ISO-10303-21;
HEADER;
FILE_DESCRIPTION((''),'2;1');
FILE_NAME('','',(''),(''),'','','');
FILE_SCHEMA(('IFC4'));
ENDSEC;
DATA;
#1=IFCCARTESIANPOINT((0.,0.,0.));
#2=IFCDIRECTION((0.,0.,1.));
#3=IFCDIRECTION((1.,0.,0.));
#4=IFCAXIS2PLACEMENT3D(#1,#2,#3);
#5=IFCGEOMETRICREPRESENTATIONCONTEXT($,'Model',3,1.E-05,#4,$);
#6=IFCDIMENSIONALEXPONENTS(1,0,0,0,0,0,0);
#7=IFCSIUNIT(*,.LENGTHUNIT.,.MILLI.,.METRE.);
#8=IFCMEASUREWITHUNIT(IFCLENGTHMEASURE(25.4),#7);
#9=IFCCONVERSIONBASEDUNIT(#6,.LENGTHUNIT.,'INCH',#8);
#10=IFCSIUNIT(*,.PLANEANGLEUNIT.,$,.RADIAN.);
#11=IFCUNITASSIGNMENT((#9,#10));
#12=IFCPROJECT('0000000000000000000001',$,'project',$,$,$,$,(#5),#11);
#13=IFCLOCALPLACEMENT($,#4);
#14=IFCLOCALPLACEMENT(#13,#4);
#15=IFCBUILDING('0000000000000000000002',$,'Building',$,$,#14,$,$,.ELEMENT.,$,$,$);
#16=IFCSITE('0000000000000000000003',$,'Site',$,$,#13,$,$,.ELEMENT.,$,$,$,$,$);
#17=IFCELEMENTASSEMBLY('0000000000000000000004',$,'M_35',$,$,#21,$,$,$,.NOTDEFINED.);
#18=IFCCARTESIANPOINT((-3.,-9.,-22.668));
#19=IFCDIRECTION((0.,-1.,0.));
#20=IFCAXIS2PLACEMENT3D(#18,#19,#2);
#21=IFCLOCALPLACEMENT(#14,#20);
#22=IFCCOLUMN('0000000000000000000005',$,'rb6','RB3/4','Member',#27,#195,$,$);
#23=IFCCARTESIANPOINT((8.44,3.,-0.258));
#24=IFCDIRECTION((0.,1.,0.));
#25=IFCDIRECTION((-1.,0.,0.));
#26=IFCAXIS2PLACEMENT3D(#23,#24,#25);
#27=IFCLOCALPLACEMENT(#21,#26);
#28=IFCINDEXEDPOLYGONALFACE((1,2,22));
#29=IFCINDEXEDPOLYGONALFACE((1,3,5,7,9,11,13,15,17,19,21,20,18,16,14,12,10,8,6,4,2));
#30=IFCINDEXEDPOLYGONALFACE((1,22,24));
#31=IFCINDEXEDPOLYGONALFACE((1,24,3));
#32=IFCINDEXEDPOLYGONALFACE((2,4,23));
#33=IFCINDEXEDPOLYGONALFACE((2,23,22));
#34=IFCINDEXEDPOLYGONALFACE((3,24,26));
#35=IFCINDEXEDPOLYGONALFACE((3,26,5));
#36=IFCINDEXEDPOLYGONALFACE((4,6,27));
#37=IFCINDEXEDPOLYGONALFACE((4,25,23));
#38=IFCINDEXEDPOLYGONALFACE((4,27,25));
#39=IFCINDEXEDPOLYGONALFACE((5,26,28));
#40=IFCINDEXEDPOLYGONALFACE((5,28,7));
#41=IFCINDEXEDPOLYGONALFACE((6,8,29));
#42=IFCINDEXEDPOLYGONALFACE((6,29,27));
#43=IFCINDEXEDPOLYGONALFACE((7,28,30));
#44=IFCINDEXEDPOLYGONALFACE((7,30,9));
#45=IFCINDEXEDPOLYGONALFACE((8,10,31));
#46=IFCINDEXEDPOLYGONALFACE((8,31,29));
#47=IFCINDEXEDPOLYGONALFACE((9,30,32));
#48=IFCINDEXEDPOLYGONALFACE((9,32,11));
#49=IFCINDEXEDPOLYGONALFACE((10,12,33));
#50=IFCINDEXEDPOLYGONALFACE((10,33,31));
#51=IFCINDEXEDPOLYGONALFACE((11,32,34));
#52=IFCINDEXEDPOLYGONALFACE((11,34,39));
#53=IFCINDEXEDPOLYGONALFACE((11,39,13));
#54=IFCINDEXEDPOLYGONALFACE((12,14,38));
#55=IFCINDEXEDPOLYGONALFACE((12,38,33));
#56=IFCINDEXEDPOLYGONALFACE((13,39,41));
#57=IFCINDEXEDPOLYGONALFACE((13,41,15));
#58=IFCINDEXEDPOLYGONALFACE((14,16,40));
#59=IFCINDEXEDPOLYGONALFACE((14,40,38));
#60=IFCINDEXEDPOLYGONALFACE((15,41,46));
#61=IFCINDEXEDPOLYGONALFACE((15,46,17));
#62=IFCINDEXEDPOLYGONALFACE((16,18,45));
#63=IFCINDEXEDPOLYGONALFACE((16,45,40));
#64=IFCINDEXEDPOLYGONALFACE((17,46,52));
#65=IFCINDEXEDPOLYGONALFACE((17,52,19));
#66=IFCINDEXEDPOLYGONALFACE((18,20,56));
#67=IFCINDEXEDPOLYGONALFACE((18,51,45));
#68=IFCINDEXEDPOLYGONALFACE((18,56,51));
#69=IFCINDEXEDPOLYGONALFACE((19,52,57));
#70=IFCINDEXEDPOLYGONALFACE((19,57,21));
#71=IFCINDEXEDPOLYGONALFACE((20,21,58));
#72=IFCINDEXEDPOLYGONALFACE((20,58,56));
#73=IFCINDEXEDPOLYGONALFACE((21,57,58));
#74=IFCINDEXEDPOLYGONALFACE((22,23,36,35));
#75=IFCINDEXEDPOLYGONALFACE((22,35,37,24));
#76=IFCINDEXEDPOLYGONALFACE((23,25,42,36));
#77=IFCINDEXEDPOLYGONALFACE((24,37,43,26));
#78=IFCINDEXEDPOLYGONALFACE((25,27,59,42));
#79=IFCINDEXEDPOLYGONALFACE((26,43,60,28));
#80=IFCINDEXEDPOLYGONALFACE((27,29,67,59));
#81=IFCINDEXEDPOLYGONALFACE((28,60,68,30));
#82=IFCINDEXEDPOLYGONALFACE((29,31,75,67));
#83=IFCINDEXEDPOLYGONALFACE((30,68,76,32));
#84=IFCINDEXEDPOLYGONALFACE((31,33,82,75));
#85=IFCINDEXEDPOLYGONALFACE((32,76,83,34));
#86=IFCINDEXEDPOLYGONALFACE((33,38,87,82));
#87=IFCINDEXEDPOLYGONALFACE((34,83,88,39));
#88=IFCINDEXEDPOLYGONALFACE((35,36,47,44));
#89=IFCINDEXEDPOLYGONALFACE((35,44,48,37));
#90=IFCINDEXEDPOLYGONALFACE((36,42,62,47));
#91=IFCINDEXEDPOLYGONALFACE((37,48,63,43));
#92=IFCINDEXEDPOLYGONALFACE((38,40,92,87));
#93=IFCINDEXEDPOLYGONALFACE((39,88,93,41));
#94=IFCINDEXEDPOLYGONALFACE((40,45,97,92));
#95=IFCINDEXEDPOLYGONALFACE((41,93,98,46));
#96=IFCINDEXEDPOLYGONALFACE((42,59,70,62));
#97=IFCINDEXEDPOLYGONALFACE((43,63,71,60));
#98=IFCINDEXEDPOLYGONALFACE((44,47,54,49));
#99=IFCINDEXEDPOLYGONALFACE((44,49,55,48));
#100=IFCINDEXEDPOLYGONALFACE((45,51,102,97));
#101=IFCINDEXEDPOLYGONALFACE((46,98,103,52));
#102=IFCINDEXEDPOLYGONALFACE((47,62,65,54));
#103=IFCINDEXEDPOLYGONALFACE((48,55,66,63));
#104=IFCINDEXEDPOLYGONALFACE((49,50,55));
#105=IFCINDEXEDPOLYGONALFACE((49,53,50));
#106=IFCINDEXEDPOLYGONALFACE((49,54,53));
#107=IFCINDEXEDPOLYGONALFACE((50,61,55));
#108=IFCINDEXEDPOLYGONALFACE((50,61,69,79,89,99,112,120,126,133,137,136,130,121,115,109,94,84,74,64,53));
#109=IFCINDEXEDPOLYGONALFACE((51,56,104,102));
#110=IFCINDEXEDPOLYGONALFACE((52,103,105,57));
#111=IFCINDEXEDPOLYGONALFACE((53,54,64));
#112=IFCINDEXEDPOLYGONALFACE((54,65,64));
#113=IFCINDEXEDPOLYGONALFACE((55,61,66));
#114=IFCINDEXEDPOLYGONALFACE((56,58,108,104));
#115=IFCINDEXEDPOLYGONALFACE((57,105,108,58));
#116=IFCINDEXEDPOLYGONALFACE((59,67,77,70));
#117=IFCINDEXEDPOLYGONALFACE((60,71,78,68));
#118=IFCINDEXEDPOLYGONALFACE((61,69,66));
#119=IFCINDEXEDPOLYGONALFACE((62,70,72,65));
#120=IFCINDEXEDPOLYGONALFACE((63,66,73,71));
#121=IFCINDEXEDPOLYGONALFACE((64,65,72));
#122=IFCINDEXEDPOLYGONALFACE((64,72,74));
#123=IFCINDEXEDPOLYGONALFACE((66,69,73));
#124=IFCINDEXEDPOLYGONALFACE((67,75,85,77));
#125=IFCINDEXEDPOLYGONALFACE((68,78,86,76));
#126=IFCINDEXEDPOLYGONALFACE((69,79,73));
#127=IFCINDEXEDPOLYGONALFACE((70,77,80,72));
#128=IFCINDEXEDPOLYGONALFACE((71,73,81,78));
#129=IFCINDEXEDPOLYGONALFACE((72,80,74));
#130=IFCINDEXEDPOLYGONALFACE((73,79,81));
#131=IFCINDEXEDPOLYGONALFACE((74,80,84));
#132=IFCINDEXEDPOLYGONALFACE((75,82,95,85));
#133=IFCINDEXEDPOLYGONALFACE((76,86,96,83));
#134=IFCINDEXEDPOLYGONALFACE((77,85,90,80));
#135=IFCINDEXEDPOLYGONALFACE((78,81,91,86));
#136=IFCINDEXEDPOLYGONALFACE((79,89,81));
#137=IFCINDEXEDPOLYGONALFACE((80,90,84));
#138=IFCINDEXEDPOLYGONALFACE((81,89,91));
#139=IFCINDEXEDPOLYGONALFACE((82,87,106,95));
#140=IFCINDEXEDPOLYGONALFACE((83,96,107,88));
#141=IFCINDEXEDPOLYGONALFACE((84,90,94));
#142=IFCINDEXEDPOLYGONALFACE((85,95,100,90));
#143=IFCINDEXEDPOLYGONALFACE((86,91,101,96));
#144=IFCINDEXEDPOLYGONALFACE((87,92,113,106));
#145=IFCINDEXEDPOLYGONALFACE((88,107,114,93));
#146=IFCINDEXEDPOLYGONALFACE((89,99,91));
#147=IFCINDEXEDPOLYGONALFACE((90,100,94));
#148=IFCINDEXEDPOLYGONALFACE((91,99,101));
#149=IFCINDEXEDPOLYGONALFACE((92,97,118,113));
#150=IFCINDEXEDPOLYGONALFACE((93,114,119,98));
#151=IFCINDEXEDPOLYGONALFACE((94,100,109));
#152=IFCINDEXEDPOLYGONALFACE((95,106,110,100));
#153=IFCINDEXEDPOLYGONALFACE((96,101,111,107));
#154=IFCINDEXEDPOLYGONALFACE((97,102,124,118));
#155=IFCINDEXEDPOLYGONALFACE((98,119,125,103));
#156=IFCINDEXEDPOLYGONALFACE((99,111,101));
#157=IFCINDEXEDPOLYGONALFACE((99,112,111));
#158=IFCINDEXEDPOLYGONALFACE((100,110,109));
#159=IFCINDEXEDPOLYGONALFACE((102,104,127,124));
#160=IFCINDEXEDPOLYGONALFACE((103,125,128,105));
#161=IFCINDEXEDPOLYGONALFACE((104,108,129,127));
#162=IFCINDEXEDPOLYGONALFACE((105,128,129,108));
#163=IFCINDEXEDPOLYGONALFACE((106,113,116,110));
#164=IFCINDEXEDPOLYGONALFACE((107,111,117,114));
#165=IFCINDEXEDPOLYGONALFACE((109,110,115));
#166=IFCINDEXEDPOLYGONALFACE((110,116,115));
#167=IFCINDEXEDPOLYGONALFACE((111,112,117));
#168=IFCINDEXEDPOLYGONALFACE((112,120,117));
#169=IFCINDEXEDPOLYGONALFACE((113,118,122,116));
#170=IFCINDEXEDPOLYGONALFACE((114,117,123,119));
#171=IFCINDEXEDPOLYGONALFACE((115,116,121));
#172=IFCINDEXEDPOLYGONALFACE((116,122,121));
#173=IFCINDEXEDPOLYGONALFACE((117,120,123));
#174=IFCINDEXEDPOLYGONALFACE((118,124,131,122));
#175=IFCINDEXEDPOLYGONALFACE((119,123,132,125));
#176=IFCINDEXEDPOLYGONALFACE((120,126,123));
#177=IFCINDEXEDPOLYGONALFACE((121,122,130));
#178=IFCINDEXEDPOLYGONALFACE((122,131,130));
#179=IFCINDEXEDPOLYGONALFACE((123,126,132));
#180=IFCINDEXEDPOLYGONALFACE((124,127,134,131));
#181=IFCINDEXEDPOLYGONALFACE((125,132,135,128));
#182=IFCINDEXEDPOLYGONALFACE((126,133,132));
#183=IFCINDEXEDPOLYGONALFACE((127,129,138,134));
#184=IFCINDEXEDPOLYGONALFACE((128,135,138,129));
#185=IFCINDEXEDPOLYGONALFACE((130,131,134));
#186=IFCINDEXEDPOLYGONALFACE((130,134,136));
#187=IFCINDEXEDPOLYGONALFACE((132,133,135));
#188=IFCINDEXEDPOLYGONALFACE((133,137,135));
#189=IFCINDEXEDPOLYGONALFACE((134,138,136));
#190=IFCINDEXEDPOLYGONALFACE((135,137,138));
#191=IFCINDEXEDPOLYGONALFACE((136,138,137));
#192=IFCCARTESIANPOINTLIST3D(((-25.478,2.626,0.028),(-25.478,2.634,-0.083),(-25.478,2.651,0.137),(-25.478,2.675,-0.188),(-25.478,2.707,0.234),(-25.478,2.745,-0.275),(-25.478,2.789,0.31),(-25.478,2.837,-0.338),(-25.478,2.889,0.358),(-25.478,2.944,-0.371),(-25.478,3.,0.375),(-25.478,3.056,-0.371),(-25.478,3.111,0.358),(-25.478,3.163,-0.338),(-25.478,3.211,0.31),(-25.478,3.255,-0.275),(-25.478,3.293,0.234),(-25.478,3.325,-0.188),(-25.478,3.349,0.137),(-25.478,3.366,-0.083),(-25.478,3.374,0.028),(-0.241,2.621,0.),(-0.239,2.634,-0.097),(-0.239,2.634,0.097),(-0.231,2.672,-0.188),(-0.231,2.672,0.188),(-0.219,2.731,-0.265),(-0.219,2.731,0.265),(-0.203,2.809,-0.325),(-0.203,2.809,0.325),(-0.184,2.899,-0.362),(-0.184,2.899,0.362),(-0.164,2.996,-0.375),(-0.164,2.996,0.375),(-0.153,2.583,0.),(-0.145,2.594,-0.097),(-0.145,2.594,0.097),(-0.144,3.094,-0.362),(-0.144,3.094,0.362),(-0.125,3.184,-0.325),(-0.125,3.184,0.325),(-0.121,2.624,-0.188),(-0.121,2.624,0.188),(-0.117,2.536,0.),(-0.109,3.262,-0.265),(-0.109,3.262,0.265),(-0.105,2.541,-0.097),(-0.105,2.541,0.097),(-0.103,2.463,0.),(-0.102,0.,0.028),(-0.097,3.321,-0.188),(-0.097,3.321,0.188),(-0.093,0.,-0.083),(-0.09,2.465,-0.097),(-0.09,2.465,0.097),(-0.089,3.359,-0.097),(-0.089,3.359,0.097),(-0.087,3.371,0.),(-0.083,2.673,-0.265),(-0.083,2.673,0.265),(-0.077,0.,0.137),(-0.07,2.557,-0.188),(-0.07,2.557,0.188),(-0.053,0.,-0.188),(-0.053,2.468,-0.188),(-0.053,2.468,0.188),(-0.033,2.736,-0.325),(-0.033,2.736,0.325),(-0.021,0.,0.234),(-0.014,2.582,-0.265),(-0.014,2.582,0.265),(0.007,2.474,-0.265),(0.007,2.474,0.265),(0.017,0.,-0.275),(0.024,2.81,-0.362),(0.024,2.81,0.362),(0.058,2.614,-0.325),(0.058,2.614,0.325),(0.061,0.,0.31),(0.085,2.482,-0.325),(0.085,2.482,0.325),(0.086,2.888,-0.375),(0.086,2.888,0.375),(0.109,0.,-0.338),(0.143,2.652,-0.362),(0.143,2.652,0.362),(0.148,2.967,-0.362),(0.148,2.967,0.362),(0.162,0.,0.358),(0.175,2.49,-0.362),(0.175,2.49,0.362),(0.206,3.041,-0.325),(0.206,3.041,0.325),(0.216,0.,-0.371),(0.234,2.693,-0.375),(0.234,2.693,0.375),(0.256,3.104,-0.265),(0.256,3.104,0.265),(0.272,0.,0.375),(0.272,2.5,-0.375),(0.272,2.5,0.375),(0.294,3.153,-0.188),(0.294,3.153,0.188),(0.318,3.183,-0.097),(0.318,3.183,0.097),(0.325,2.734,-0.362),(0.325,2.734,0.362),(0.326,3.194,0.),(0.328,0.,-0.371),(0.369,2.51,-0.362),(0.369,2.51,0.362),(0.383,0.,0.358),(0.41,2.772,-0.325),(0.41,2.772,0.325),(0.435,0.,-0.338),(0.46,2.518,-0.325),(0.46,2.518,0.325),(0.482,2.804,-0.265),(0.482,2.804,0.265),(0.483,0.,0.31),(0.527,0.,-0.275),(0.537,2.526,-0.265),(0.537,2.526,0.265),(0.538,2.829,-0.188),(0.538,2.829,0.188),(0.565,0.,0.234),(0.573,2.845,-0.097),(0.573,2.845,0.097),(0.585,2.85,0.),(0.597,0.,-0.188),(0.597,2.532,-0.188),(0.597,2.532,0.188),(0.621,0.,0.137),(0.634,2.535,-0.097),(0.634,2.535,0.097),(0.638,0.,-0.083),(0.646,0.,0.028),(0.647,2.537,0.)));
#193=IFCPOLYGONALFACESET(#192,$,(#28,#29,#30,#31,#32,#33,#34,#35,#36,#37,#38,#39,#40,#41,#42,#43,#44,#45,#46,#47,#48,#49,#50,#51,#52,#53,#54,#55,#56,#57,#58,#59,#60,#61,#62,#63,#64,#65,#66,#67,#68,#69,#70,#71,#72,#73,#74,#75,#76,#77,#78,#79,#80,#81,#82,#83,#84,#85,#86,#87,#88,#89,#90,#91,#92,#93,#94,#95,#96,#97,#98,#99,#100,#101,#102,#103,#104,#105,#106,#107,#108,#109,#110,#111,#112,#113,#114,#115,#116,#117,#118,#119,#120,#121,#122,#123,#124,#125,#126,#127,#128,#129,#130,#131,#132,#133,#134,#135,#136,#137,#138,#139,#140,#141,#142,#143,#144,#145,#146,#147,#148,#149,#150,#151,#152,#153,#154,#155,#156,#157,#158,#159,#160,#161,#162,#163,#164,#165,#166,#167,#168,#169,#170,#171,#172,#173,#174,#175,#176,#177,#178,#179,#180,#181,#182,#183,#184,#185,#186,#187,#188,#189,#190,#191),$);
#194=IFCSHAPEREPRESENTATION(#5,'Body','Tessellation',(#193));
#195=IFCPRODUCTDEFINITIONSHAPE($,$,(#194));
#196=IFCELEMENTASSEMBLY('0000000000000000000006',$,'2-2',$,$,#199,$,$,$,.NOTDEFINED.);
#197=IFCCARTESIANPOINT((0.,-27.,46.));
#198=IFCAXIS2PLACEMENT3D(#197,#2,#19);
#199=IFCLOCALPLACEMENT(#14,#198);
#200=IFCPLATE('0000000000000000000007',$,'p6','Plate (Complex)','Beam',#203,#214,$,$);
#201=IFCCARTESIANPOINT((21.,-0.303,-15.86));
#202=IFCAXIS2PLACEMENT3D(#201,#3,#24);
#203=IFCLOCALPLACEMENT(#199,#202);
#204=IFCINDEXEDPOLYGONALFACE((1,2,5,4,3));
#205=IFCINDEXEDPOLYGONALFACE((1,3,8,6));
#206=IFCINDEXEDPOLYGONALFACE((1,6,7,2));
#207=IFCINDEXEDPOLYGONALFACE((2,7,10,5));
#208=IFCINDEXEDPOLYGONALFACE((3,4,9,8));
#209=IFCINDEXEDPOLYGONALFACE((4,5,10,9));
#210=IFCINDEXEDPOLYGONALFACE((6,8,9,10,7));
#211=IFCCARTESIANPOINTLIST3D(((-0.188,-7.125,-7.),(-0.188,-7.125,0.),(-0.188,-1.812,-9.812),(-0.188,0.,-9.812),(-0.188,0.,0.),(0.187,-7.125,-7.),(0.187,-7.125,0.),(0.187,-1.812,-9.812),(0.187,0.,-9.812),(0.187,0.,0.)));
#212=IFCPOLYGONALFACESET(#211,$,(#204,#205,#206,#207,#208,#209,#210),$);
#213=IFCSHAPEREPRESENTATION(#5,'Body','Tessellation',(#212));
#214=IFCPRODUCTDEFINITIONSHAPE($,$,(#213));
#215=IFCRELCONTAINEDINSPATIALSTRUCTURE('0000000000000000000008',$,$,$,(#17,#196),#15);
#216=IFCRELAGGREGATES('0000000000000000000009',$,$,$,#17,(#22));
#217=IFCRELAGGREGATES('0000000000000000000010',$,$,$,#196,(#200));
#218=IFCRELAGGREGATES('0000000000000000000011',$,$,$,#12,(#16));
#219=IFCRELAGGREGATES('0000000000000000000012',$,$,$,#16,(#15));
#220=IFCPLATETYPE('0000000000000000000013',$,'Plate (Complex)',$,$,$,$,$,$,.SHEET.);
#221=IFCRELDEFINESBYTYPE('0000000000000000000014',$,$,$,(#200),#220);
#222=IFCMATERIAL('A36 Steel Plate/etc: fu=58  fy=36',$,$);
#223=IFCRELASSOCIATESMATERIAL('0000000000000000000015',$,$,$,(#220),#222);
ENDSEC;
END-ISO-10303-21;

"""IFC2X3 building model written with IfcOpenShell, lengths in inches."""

from ifc_helpers import new_model, entity, si_unit, converted_unit, frame, origin_with_axes, place, context, project, spatial, polyline, outline, extrude, source, transform, mapped, material, type_object, type_shapes, element, aggregate, save


model = new_model("IFC2X3")

# Units and contexts
model_context = context("Model", 3, precision=1e-05, world=origin_with_axes())
ifc_project = project(units=[converted_unit("LENGTHUNIT", "INCH", entity("IfcLengthMeasure", 25.4), si_unit("LENGTHUNIT", "METRE", prefix="MILLI"), dimensions=[1, 0, 0, 0, 0, 0, 0]), si_unit("PLANEANGLEUNIT", "RADIAN")], contexts=[model_context])

# Site, building
site_placement = place(None, origin_with_axes())
site = spatial("IfcSite", under=ifc_project, at=site_placement, Name="Site", CompositionType="ELEMENT")
building_placement = place(site_placement, origin_with_axes())
building = spatial("IfcBuilding", under=site, at=building_placement, Name="Building", CompositionType="ELEMENT")

# Element assembly, column
assembly_1_placement = place(building_placement, frame((-3.0, -9.0, -22.668), z_axis=(0.0, -1.0, 0.0), x_axis=(0.0, 0.0, 1.0)))
assembly_1 = element("IfcElementAssembly", 1, at=assembly_1_placement, inside=building, Name="M_35", PredefinedType="NOTDEFINED")
column_placement = place(assembly_1_placement, frame((8.44, 3.0, -0.258), z_axis=(0.0, 1.0, 0.0), x_axis=(-1.0, 0.0, 0.0)))
cartesian_point = entity("IfcCartesianPoint", [0.0, 0.0, 0.0])
ifc_direction_1 = entity("IfcDirection", [0.0, 0.0, 1.0])
ifc_direction_2 = entity("IfcDirection", [1.0, 0.0, 0.0])
column = element("IfcColumn", 2, at=column_placement, Name="rb6", Description="RB3/4", ObjectType="Member", context=model_context, shape_type="SweptSolid", body=[
    entity("IfcSurfaceCurveSweptAreaSolid", entity("IfcCircleProfileDef", "AREA", None, entity("IfcAxis2Placement2D", entity("IfcCartesianPoint", [0.0, 0.0]), entity("IfcDirection", [1.0, 0.0])), 0.375), entity("IfcAxis2Placement3D", cartesian_point, ifc_direction_1, ifc_direction_2), entity("IfcPolyline", [entity("IfcCartesianPoint", [0.272, 0.0]), entity("IfcCartesianPoint", [0.272, 2.5]), entity("IfcCartesianPoint", [0.234, 2.693]), entity("IfcCartesianPoint", [0.086, 2.888]), entity("IfcCartesianPoint", [-0.164, 2.996]), entity("IfcCartesianPoint", [-25.478, 3.0])]), 0.0, 1.0, entity("IfcPlane", entity("IfcAxis2Placement3D", cartesian_point, ifc_direction_1, ifc_direction_2))),
])
ifc_material = material(Name="A36 Steel Plate/etc: fu=58  fy=36")
aggregate(assembly_1, [column])

# Element assembly, plate
assembly_2_placement = place(building_placement, frame((0.0, -27.0, 46.0), z_axis=(0.0, 0.0, 1.0), x_axis=(0.0, -1.0, 0.0)))
assembly_2 = element("IfcElementAssembly", 3, at=assembly_2_placement, inside=building, Name="2-2", PredefinedType="NOTDEFINED")
plate_type_1 = type_object("IfcPlateType", Name="Plate (Complex)", PredefinedType="SHEET", material=ifc_material)
shared_shape_1 = source(origin_with_axes(), model_context, "Body", "SweptSolid", [
    extrude(outline(polyline([(0.0, -9.812), (-1.812, -9.812), (-7.125, -7.0), (-7.125, 0.0), (0.0, 0.0), (0.0, -9.812)])), frame((-0.188, 0.0, 0.0), z_axis=(1.0, 0.0, 0.0), x_axis=(0.0, 1.0, 0.0)), (0.0, 0.0, 1.0), 0.375),
])
type_shapes(plate_type_1, [shared_shape_1])
plate_1_placement = place(assembly_2_placement, frame((21.0, -0.303, -15.86), z_axis=(1.0, 0.0, 0.0), x_axis=(0.0, 1.0, 0.0)))
plate_1 = element("IfcPlate", 4, at=plate_1_placement, type_object=plate_type_1, Name="p6", Description="Plate (Complex)", ObjectType="Beam", context=model_context, shape_type="MappedRepresentation", body=[
    mapped(shared_shape_1, transform((0.0, 0.0, 0.0), scale=1.0)),
])
aggregate(assembly_2, [plate_1])

save(model, "model.ifc")
